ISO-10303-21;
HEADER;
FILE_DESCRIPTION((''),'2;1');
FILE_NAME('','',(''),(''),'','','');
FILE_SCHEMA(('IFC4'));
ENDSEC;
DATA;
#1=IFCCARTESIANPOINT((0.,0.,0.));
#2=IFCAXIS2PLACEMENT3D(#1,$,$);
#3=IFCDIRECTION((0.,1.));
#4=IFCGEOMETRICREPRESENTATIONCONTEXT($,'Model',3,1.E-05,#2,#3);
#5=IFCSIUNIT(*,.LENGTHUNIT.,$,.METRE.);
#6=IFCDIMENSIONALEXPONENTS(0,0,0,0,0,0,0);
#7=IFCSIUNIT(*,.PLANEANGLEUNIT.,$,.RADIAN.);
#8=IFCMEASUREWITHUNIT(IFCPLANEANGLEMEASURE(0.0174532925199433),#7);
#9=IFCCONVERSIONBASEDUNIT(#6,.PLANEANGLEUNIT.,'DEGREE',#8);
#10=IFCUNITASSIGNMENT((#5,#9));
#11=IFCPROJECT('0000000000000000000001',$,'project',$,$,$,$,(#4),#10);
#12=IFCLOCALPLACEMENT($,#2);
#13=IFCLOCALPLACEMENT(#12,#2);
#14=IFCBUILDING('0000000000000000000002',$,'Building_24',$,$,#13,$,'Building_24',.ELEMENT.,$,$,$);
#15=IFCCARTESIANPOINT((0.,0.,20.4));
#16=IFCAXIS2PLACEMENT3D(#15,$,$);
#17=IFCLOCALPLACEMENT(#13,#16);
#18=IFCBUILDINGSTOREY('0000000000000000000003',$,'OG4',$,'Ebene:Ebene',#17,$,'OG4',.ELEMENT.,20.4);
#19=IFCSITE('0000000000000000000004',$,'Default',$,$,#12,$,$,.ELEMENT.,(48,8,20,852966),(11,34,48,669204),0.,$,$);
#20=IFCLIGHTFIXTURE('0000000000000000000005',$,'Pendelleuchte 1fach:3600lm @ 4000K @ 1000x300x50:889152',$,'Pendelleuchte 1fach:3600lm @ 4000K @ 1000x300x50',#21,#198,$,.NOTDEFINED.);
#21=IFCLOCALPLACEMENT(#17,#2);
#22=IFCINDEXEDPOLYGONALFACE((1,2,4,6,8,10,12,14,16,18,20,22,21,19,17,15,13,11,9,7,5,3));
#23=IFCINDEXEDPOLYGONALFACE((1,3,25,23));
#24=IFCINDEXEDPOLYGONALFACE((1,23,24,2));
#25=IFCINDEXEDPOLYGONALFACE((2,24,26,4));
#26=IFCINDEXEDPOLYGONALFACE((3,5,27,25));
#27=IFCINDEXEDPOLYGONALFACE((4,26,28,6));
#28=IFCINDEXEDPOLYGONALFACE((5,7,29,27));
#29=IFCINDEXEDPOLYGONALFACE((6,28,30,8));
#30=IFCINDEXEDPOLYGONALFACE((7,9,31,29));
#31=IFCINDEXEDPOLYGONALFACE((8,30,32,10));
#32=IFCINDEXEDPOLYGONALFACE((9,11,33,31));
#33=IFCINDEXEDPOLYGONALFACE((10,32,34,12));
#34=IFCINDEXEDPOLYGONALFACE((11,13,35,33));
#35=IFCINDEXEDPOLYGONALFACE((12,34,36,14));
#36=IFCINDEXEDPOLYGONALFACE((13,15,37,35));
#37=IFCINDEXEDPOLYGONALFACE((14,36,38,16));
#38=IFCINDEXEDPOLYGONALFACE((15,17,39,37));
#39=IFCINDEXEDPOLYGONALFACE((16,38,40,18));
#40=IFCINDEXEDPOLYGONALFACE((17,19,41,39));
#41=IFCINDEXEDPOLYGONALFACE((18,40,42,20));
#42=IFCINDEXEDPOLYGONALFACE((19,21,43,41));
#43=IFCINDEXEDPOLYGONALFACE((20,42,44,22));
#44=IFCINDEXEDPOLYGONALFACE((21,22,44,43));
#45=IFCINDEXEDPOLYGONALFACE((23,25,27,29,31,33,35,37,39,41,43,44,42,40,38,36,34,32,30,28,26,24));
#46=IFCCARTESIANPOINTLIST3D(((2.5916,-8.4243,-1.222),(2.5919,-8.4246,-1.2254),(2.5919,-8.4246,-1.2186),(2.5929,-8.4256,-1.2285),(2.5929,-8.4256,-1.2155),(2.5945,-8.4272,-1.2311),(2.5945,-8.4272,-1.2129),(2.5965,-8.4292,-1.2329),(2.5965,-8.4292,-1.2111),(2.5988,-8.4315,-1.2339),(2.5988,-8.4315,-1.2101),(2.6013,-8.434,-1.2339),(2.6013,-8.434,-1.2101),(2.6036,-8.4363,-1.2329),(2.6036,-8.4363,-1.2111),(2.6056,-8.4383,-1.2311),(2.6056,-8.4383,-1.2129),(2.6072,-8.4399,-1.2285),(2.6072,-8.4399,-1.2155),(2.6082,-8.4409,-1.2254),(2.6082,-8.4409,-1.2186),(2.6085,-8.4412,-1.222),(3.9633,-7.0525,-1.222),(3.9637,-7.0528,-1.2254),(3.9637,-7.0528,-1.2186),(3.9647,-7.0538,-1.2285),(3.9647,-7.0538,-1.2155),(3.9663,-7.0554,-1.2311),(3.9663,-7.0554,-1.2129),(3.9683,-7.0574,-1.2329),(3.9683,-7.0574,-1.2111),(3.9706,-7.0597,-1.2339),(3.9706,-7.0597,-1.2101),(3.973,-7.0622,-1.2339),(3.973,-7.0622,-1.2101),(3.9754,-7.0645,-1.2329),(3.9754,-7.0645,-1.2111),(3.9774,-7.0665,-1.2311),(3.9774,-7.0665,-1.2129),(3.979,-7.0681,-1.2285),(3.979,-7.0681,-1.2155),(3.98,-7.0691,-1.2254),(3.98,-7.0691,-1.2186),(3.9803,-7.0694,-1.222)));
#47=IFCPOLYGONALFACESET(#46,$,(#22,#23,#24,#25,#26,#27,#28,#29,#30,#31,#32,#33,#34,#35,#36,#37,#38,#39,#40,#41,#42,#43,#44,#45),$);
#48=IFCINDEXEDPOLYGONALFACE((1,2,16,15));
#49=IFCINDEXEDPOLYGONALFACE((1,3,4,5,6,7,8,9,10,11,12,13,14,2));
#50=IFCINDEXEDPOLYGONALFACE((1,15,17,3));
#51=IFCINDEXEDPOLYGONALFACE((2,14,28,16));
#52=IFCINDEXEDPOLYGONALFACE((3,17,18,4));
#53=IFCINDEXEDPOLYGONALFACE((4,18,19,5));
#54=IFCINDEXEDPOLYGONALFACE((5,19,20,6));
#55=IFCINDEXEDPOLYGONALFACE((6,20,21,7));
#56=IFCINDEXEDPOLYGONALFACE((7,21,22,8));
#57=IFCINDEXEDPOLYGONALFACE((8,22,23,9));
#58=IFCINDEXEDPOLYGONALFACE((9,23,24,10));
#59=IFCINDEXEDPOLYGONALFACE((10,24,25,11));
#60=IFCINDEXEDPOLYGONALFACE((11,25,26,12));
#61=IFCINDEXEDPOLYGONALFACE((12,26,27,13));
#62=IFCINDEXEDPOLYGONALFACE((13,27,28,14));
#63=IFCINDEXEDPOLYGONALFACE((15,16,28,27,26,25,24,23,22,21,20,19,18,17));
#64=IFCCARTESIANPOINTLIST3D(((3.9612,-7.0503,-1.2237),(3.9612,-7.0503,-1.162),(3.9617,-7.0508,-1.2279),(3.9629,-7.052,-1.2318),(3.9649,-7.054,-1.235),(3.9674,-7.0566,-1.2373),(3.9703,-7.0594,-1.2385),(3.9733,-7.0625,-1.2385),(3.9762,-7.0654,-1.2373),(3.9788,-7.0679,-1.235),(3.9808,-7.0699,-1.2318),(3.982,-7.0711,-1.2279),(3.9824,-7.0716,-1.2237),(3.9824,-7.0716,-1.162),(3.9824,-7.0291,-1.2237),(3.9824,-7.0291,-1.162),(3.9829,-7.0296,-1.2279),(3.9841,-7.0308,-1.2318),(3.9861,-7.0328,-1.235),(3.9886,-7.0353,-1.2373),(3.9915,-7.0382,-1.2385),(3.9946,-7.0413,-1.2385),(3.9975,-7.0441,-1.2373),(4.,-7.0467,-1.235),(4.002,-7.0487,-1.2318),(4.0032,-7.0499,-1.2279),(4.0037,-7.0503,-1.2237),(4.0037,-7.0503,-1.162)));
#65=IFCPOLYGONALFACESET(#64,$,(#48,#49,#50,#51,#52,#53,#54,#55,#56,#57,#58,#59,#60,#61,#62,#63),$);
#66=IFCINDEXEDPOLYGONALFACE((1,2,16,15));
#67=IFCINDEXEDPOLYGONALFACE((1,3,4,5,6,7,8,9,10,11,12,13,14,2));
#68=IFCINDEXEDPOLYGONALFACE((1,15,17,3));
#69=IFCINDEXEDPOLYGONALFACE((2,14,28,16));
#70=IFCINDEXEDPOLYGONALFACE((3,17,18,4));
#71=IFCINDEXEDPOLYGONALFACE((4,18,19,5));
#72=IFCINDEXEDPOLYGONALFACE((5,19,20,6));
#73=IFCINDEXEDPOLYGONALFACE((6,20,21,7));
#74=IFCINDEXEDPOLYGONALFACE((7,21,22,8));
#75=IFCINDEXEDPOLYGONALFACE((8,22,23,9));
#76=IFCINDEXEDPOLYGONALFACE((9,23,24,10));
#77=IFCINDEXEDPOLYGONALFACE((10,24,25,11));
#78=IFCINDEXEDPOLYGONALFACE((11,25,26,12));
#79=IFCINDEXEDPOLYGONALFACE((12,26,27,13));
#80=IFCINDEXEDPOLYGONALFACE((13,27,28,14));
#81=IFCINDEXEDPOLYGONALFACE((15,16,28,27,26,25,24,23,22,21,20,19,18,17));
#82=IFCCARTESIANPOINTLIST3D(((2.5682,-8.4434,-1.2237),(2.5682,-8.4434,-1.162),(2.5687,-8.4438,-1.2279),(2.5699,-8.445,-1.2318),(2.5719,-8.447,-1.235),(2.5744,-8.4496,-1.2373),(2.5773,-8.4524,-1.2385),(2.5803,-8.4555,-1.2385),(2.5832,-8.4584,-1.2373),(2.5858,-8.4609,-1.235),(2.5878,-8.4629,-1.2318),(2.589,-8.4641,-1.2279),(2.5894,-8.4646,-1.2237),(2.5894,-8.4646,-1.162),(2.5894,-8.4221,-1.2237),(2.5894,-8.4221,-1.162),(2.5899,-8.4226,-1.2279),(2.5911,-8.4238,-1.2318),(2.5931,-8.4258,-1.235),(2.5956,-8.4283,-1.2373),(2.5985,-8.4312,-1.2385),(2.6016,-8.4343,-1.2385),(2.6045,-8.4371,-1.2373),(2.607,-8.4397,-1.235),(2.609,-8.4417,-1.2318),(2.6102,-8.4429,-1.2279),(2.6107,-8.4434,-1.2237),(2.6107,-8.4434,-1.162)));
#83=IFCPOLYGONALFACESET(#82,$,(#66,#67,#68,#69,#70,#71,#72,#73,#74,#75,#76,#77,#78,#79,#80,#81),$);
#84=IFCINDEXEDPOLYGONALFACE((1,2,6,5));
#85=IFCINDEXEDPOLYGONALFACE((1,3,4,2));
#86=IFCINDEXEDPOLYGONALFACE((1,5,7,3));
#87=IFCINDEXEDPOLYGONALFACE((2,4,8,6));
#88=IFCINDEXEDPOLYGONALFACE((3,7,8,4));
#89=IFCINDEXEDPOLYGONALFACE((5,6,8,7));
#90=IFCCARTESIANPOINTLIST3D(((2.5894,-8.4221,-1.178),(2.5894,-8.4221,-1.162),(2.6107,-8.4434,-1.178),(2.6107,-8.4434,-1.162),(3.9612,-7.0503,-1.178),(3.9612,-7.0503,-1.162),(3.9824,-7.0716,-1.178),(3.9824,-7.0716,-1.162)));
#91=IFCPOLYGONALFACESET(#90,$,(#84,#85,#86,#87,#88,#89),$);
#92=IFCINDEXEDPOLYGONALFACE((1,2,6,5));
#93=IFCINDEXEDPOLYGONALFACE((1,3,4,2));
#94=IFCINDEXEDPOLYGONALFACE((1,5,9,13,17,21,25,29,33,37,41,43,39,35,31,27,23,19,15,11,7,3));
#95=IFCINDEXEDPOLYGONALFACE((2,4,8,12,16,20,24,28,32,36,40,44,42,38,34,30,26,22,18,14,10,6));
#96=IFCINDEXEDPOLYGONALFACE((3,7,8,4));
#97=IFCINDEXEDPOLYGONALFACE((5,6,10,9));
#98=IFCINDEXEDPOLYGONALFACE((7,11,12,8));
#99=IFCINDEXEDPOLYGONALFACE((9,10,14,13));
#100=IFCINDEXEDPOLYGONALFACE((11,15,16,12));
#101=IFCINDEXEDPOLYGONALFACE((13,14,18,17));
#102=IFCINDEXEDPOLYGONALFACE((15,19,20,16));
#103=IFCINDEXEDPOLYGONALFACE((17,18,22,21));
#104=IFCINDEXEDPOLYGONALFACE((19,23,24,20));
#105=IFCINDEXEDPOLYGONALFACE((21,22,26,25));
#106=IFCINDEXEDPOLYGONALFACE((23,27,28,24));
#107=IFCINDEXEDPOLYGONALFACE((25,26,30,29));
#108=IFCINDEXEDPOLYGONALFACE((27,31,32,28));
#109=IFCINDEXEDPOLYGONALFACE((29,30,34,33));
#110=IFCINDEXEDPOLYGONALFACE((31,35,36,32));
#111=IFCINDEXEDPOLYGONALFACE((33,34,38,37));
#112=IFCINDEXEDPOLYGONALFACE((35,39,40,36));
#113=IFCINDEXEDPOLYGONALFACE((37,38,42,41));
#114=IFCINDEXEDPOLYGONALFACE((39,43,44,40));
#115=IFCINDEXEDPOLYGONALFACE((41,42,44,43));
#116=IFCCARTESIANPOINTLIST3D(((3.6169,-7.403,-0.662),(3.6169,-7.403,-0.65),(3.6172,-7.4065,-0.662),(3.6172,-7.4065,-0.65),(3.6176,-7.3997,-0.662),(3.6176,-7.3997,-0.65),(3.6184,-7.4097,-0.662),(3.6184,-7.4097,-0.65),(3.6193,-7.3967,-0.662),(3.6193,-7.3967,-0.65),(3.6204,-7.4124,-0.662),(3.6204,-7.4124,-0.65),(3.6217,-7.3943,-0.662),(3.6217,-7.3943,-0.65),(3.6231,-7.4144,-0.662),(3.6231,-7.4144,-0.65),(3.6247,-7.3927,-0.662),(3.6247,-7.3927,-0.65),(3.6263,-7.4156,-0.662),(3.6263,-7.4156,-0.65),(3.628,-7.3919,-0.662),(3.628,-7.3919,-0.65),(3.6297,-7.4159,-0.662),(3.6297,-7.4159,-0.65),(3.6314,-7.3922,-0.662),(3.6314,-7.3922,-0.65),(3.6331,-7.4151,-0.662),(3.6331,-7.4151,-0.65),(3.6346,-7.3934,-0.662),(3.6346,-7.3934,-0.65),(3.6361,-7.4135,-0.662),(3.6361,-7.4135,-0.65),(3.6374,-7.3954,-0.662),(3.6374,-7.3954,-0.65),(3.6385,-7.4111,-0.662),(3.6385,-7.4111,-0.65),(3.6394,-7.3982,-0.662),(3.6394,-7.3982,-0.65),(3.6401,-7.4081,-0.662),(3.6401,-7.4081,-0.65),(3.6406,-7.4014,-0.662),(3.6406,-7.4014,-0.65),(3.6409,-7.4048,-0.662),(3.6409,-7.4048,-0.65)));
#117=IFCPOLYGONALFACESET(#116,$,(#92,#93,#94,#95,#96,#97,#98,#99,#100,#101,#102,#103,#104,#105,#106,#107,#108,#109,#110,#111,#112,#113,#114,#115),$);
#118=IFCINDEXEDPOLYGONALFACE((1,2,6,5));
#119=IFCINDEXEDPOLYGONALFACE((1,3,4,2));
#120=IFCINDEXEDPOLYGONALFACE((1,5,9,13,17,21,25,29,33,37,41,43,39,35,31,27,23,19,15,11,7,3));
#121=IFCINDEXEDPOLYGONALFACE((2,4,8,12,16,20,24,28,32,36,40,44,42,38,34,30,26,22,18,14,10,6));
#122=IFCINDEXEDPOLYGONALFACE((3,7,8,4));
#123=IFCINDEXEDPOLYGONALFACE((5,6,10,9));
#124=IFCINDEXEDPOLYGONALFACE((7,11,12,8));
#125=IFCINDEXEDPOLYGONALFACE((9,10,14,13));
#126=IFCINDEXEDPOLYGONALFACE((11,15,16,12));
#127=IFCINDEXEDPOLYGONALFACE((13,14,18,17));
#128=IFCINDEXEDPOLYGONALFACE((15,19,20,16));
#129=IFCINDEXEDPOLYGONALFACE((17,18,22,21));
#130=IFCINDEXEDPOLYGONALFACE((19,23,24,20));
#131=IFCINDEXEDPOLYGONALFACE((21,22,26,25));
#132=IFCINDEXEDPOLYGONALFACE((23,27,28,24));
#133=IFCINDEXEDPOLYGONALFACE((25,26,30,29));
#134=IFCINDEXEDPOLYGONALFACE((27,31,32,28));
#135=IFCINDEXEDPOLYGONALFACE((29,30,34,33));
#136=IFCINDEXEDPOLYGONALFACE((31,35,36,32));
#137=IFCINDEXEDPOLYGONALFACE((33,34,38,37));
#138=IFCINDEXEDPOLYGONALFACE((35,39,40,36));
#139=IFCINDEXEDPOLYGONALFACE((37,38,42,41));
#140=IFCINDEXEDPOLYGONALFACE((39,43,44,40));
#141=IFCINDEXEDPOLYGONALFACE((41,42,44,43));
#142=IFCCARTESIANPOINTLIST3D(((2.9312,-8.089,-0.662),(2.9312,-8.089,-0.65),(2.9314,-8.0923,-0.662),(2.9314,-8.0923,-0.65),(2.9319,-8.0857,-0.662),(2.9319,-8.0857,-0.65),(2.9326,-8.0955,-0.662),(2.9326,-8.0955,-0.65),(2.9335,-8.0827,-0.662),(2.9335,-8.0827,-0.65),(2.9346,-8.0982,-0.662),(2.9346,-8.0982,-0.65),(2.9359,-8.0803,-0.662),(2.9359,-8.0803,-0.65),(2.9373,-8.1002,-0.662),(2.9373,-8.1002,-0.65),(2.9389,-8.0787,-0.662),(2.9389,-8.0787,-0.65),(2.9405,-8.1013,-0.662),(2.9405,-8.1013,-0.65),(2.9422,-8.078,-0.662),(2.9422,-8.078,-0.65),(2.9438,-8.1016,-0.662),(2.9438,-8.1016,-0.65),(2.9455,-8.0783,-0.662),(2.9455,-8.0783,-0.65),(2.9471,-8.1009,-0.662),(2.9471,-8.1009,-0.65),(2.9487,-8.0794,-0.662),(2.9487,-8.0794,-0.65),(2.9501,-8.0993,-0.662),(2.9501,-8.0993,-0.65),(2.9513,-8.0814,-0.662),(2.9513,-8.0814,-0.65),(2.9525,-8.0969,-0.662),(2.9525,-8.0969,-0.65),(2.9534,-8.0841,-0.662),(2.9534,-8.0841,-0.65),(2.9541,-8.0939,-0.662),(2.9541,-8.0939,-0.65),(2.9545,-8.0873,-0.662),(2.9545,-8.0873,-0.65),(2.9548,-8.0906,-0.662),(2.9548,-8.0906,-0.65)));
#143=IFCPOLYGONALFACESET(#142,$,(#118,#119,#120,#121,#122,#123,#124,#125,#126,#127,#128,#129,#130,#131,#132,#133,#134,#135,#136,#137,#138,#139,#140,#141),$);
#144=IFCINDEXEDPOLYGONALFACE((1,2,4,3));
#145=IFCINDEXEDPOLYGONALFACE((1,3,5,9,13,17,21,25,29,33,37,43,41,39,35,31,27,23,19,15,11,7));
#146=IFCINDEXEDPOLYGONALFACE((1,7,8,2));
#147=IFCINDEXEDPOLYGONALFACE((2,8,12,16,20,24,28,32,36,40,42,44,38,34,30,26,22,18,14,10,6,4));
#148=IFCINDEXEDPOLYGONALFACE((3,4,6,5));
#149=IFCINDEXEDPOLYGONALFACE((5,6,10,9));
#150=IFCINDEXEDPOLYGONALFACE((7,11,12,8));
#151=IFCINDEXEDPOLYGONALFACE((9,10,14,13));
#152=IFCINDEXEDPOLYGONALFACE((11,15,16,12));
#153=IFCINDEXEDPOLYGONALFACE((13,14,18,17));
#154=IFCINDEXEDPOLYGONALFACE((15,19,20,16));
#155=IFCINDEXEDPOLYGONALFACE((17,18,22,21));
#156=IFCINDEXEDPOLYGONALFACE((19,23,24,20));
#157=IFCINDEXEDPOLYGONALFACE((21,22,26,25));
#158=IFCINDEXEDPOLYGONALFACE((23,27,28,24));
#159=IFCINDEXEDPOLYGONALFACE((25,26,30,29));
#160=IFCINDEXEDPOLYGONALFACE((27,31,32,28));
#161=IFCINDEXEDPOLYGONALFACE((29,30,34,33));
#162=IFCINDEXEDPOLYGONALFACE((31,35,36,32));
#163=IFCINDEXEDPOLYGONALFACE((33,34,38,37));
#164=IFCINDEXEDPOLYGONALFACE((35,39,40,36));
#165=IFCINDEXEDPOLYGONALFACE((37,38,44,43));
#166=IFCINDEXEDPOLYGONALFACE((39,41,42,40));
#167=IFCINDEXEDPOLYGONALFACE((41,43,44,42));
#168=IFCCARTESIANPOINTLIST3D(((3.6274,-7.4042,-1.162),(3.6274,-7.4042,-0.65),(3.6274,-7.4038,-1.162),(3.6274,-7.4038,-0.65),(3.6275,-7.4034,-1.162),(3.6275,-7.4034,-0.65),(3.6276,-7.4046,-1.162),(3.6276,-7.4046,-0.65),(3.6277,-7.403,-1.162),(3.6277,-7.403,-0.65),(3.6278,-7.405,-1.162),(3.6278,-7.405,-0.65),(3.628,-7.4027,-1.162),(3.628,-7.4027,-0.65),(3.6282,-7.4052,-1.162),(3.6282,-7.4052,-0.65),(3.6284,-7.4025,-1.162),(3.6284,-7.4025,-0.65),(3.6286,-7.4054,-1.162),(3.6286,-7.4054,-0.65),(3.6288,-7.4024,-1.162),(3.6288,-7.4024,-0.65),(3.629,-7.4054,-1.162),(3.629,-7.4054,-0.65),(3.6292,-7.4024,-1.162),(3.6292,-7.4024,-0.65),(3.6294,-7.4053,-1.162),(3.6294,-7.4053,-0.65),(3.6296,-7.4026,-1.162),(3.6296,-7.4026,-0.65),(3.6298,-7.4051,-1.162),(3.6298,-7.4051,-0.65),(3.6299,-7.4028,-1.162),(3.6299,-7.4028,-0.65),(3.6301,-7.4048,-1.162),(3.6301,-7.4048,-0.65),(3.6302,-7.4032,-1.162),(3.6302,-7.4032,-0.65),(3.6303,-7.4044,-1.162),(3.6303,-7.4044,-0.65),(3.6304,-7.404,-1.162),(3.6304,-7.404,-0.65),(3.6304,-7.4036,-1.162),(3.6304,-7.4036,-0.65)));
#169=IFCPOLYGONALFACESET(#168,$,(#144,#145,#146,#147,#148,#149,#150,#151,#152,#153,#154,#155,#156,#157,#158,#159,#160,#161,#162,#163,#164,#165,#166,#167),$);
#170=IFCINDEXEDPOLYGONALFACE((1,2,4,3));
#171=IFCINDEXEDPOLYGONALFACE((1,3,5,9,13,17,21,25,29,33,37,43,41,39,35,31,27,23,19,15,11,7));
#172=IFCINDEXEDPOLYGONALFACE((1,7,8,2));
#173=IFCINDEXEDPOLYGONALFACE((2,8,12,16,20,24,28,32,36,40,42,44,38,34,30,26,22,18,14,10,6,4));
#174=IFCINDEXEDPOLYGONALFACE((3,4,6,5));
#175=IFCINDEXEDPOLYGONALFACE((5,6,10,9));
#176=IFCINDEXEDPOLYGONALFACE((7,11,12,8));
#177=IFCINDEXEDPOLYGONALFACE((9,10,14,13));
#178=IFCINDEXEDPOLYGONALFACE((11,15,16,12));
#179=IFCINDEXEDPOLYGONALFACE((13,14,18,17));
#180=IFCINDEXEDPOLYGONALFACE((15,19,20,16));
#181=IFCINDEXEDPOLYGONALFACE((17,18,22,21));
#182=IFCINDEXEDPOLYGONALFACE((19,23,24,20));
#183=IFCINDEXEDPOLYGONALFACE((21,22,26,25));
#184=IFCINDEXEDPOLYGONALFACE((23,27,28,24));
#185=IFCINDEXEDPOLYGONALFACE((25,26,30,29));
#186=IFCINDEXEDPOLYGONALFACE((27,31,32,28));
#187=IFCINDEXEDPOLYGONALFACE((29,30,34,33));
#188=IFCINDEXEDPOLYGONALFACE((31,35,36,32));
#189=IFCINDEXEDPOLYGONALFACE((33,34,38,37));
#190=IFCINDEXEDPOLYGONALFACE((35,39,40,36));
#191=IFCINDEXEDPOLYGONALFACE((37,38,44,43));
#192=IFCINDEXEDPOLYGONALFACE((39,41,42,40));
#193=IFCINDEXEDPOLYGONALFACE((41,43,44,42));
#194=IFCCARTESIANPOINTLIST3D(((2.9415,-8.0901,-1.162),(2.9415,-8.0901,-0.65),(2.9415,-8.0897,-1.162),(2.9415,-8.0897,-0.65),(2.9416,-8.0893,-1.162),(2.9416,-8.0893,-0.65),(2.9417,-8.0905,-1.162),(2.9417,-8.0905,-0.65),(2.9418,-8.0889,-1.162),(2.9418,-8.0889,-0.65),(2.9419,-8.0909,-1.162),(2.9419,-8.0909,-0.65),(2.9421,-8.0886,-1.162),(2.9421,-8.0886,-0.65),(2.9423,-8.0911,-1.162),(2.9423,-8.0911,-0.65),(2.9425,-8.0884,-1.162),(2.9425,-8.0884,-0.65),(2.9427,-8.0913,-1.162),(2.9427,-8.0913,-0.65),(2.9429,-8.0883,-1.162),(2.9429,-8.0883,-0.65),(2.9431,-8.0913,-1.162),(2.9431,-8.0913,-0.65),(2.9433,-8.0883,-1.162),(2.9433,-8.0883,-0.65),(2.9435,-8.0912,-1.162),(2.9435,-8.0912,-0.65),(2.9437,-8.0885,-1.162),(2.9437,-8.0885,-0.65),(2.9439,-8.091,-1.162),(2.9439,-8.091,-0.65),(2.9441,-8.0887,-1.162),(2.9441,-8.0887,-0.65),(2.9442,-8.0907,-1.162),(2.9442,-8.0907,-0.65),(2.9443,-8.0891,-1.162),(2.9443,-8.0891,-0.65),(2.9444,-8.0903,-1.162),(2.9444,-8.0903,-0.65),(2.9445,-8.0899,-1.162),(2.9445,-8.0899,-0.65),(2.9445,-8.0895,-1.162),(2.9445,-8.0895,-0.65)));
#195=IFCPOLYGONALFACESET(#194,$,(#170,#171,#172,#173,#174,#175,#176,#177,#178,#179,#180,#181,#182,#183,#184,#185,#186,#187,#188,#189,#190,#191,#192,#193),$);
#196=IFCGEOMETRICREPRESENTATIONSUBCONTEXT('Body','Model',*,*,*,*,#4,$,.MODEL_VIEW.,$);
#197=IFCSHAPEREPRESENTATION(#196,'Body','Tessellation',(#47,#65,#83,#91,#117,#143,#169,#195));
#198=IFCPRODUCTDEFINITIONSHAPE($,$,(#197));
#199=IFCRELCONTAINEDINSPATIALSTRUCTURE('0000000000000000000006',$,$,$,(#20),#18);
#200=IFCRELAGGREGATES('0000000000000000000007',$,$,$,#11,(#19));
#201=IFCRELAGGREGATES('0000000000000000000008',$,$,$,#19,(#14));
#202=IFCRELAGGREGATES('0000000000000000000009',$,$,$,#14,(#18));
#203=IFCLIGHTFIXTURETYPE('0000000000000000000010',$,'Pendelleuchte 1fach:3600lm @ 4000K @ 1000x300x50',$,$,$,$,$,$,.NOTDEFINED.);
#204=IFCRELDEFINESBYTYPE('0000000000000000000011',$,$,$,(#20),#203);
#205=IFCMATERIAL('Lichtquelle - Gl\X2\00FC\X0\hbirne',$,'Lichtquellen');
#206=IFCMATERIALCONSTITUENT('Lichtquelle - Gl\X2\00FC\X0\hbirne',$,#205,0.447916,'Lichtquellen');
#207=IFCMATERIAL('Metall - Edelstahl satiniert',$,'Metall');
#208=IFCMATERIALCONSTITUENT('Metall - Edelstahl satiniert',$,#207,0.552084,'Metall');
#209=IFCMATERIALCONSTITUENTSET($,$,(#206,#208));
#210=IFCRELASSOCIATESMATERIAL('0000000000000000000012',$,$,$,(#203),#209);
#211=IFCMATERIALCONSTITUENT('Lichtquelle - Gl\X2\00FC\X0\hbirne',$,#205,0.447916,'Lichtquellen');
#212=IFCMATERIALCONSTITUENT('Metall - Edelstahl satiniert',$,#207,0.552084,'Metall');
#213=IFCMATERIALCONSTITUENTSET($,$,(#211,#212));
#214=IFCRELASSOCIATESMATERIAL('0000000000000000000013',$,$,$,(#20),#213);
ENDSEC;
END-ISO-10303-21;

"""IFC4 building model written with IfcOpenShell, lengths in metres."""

from ifc_helpers import new_model, entity, si_unit, converted_unit, direction, frame, origin, place, context, subcontext, project, spatial, line, arc, indexed_curve, outline, extrude, source, transform, mapped, material, constituent, constituent_set, type_object, type_shapes, element, save


model = new_model("IFC4")

# Units and contexts
model_context = context("Model", 3, precision=1e-05, world=origin(), true_north=direction((0.0, 1.0)))
body_context = subcontext(model_context, "Body", "Model", "MODEL_VIEW")
ifc_project = project(units=[si_unit("LENGTHUNIT", "METRE"), converted_unit("PLANEANGLEUNIT", "DEGREE", entity("IfcPlaneAngleMeasure", 0.0174532925199433), si_unit("PLANEANGLEUNIT", "RADIAN"), dimensions=[0, 0, 0, 0, 0, 0, 0])], contexts=[model_context])

# Site, building, storey
site_placement = place(None, origin())
site = spatial("IfcSite", under=ifc_project, at=site_placement, Name="Default", CompositionType="ELEMENT", RefLatitude=(48, 8, 20, 852966), RefLongitude=(11, 34, 48, 669204), RefElevation=0.0)
building_placement = place(site_placement, origin())
building = spatial("IfcBuilding", under=site, at=building_placement, Name="Building_24", LongName="Building_24", CompositionType="ELEMENT")
storey_placement = place(building_placement, frame((0.0, 0.0, 20.4)))
storey = spatial("IfcBuildingStorey", under=building, at=storey_placement, Name="OG4", ObjectType="Ebene:Ebene", LongName="OG4", CompositionType="ELEMENT", Elevation=20.4)

# Light fixture
ifc_material_1 = material(Name="Lichtquelle - Glühbirne", Category="Lichtquellen")
ifc_material_2 = material(Name="Metall - Edelstahl satiniert", Category="Metall")
ifc_constituent_1 = constituent(ifc_material_1, Name="Lichtquelle - Glühbirne", Category="Lichtquellen", fraction=0.447916)
ifc_constituent_2 = constituent(ifc_material_2, Name="Metall - Edelstahl satiniert", Category="Metall", fraction=0.552084)
ifc_constituent_set_1 = constituent_set(constituents=[ifc_constituent_1, ifc_constituent_2])
light_fixture_type = type_object("IfcLightFixtureType", Name="Pendelleuchte 1fach:3600lm @ 4000K @ 1000x300x50", PredefinedType="NOTDEFINED", material=ifc_constituent_set_1)
shared_shape_1 = source(origin(), body_context, "Body", "SweptSolid", [
    extrude(outline(indexed_curve([(-0.012, 0.0), (0.0, -0.012), (0.012, 0.0), (0.0, 0.012)], segments=[arc(1, 2, 3), arc(3, 4, 1)], self_intersect=False)), frame((-0.97, 0.0, -0.572), z_axis=(1.0, 0.0, 0.0), x_axis=(0.0, 1.0, 0.0)), (0.0, 0.0, 1.0), 1.94),
    extrude(outline(indexed_curve([(-0.0308, -0.015), (0.0308, -0.015), (0.0308, 0.015), (-0.0308, 0.015), (-0.0458, 0.0)], segments=[line(1, 2, 3, 4), arc(4, 5, 1)], self_intersect=False)), frame((0.97, 0.0, -0.5428), z_axis=(1.0, 0.0, 0.0), x_axis=(0.0, 0.0, 1.0)), (0.0, 0.0, 1.0), 0.03),
    extrude(outline(indexed_curve([(-0.0308, -0.015), (0.0308, -0.015), (0.0308, 0.015), (-0.0308, 0.015), (-0.0458, 0.0)], segments=[line(1, 2, 3, 4), arc(4, 5, 1)], self_intersect=False)), frame((-1.0, 0.0, -0.5428), z_axis=(1.0, 0.0, 0.0), x_axis=(0.0, 0.0, 1.0)), (0.0, 0.0, 1.0), 0.03),
    extrude(outline(indexed_curve([(-0.97, -0.015), (0.97, -0.015), (0.97, 0.015), (-0.97, 0.015), (-0.97, -0.015)], self_intersect=False)), frame((0.0, 0.0, -0.528), z_axis=(0.0, 0.0, 1.0), x_axis=(-1.0, 0.0, 0.0)), (0.0, 0.0, 1.0), 0.016),
    extrude(outline(indexed_curve([(-0.012, 0.0), (0.0, -0.012), (0.012, 0.0), (0.0, 0.012)], segments=[arc(1, 2, 3), arc(3, 4, 1)], self_intersect=False)), frame((0.485, 0.0, -0.012)), (0.0, 0.0, 1.0), 0.012),
    extrude(outline(indexed_curve([(-0.0118, 0.0), (0.0, -0.0118), (0.0118, 0.0), (0.0, 0.0118)], segments=[arc(1, 2, 3), arc(3, 4, 1)], self_intersect=False)), frame((-0.485, 0.0, -0.012)), (0.0, 0.0, 1.0), 0.012),
    extrude(outline(indexed_curve([(-0.0015, 0.0), (0.0, -0.0015), (0.0015, 0.0), (0.0, 0.0015)], segments=[arc(1, 2, 3), arc(3, 4, 1)], self_intersect=False)), frame((0.485, 0.0, -0.512)), (0.0, 0.0, 1.0), 0.512),
    extrude(outline(indexed_curve([(-0.0015, 0.0), (0.0, -0.0015), (0.0015, 0.0), (0.0, 0.0015)], segments=[arc(1, 2, 3), arc(3, 4, 1)], self_intersect=False)), frame((-0.485, 0.0, -0.512)), (0.0, 0.0, 1.0), 0.512),
])
type_shapes(light_fixture_type, [shared_shape_1])
ifc_constituent_3 = constituent(ifc_material_1, Name="Lichtquelle - Glühbirne", Category="Lichtquellen", fraction=0.447916)
ifc_constituent_4 = constituent(ifc_material_2, Name="Metall - Edelstahl satiniert", Category="Metall", fraction=0.552084)
ifc_constituent_set_2 = constituent_set(constituents=[ifc_constituent_3, ifc_constituent_4])
light_fixture_1_placement = place(storey_placement, frame((3.2859, -7.7469, -0.65), z_axis=(0.0, 0.0, 1.0), x_axis=(0.707107, 0.707107, 0.0)))
element("IfcLightFixture", 1, at=light_fixture_1_placement, inside=storey, type_object=light_fixture_type, material=ifc_constituent_set_2, Name="Pendelleuchte 1fach:3600lm @ 4000K @ 1000x300x50:889152", ObjectType="Pendelleuchte 1fach:3600lm @ 4000K @ 1000x300x50", PredefinedType="NOTDEFINED", context=body_context, shape_type="MappedRepresentation", body=[
    mapped(shared_shape_1, transform((0.0, 0.0, 0.0), scale=1.0)),
])

save(model, "model.ifc")
